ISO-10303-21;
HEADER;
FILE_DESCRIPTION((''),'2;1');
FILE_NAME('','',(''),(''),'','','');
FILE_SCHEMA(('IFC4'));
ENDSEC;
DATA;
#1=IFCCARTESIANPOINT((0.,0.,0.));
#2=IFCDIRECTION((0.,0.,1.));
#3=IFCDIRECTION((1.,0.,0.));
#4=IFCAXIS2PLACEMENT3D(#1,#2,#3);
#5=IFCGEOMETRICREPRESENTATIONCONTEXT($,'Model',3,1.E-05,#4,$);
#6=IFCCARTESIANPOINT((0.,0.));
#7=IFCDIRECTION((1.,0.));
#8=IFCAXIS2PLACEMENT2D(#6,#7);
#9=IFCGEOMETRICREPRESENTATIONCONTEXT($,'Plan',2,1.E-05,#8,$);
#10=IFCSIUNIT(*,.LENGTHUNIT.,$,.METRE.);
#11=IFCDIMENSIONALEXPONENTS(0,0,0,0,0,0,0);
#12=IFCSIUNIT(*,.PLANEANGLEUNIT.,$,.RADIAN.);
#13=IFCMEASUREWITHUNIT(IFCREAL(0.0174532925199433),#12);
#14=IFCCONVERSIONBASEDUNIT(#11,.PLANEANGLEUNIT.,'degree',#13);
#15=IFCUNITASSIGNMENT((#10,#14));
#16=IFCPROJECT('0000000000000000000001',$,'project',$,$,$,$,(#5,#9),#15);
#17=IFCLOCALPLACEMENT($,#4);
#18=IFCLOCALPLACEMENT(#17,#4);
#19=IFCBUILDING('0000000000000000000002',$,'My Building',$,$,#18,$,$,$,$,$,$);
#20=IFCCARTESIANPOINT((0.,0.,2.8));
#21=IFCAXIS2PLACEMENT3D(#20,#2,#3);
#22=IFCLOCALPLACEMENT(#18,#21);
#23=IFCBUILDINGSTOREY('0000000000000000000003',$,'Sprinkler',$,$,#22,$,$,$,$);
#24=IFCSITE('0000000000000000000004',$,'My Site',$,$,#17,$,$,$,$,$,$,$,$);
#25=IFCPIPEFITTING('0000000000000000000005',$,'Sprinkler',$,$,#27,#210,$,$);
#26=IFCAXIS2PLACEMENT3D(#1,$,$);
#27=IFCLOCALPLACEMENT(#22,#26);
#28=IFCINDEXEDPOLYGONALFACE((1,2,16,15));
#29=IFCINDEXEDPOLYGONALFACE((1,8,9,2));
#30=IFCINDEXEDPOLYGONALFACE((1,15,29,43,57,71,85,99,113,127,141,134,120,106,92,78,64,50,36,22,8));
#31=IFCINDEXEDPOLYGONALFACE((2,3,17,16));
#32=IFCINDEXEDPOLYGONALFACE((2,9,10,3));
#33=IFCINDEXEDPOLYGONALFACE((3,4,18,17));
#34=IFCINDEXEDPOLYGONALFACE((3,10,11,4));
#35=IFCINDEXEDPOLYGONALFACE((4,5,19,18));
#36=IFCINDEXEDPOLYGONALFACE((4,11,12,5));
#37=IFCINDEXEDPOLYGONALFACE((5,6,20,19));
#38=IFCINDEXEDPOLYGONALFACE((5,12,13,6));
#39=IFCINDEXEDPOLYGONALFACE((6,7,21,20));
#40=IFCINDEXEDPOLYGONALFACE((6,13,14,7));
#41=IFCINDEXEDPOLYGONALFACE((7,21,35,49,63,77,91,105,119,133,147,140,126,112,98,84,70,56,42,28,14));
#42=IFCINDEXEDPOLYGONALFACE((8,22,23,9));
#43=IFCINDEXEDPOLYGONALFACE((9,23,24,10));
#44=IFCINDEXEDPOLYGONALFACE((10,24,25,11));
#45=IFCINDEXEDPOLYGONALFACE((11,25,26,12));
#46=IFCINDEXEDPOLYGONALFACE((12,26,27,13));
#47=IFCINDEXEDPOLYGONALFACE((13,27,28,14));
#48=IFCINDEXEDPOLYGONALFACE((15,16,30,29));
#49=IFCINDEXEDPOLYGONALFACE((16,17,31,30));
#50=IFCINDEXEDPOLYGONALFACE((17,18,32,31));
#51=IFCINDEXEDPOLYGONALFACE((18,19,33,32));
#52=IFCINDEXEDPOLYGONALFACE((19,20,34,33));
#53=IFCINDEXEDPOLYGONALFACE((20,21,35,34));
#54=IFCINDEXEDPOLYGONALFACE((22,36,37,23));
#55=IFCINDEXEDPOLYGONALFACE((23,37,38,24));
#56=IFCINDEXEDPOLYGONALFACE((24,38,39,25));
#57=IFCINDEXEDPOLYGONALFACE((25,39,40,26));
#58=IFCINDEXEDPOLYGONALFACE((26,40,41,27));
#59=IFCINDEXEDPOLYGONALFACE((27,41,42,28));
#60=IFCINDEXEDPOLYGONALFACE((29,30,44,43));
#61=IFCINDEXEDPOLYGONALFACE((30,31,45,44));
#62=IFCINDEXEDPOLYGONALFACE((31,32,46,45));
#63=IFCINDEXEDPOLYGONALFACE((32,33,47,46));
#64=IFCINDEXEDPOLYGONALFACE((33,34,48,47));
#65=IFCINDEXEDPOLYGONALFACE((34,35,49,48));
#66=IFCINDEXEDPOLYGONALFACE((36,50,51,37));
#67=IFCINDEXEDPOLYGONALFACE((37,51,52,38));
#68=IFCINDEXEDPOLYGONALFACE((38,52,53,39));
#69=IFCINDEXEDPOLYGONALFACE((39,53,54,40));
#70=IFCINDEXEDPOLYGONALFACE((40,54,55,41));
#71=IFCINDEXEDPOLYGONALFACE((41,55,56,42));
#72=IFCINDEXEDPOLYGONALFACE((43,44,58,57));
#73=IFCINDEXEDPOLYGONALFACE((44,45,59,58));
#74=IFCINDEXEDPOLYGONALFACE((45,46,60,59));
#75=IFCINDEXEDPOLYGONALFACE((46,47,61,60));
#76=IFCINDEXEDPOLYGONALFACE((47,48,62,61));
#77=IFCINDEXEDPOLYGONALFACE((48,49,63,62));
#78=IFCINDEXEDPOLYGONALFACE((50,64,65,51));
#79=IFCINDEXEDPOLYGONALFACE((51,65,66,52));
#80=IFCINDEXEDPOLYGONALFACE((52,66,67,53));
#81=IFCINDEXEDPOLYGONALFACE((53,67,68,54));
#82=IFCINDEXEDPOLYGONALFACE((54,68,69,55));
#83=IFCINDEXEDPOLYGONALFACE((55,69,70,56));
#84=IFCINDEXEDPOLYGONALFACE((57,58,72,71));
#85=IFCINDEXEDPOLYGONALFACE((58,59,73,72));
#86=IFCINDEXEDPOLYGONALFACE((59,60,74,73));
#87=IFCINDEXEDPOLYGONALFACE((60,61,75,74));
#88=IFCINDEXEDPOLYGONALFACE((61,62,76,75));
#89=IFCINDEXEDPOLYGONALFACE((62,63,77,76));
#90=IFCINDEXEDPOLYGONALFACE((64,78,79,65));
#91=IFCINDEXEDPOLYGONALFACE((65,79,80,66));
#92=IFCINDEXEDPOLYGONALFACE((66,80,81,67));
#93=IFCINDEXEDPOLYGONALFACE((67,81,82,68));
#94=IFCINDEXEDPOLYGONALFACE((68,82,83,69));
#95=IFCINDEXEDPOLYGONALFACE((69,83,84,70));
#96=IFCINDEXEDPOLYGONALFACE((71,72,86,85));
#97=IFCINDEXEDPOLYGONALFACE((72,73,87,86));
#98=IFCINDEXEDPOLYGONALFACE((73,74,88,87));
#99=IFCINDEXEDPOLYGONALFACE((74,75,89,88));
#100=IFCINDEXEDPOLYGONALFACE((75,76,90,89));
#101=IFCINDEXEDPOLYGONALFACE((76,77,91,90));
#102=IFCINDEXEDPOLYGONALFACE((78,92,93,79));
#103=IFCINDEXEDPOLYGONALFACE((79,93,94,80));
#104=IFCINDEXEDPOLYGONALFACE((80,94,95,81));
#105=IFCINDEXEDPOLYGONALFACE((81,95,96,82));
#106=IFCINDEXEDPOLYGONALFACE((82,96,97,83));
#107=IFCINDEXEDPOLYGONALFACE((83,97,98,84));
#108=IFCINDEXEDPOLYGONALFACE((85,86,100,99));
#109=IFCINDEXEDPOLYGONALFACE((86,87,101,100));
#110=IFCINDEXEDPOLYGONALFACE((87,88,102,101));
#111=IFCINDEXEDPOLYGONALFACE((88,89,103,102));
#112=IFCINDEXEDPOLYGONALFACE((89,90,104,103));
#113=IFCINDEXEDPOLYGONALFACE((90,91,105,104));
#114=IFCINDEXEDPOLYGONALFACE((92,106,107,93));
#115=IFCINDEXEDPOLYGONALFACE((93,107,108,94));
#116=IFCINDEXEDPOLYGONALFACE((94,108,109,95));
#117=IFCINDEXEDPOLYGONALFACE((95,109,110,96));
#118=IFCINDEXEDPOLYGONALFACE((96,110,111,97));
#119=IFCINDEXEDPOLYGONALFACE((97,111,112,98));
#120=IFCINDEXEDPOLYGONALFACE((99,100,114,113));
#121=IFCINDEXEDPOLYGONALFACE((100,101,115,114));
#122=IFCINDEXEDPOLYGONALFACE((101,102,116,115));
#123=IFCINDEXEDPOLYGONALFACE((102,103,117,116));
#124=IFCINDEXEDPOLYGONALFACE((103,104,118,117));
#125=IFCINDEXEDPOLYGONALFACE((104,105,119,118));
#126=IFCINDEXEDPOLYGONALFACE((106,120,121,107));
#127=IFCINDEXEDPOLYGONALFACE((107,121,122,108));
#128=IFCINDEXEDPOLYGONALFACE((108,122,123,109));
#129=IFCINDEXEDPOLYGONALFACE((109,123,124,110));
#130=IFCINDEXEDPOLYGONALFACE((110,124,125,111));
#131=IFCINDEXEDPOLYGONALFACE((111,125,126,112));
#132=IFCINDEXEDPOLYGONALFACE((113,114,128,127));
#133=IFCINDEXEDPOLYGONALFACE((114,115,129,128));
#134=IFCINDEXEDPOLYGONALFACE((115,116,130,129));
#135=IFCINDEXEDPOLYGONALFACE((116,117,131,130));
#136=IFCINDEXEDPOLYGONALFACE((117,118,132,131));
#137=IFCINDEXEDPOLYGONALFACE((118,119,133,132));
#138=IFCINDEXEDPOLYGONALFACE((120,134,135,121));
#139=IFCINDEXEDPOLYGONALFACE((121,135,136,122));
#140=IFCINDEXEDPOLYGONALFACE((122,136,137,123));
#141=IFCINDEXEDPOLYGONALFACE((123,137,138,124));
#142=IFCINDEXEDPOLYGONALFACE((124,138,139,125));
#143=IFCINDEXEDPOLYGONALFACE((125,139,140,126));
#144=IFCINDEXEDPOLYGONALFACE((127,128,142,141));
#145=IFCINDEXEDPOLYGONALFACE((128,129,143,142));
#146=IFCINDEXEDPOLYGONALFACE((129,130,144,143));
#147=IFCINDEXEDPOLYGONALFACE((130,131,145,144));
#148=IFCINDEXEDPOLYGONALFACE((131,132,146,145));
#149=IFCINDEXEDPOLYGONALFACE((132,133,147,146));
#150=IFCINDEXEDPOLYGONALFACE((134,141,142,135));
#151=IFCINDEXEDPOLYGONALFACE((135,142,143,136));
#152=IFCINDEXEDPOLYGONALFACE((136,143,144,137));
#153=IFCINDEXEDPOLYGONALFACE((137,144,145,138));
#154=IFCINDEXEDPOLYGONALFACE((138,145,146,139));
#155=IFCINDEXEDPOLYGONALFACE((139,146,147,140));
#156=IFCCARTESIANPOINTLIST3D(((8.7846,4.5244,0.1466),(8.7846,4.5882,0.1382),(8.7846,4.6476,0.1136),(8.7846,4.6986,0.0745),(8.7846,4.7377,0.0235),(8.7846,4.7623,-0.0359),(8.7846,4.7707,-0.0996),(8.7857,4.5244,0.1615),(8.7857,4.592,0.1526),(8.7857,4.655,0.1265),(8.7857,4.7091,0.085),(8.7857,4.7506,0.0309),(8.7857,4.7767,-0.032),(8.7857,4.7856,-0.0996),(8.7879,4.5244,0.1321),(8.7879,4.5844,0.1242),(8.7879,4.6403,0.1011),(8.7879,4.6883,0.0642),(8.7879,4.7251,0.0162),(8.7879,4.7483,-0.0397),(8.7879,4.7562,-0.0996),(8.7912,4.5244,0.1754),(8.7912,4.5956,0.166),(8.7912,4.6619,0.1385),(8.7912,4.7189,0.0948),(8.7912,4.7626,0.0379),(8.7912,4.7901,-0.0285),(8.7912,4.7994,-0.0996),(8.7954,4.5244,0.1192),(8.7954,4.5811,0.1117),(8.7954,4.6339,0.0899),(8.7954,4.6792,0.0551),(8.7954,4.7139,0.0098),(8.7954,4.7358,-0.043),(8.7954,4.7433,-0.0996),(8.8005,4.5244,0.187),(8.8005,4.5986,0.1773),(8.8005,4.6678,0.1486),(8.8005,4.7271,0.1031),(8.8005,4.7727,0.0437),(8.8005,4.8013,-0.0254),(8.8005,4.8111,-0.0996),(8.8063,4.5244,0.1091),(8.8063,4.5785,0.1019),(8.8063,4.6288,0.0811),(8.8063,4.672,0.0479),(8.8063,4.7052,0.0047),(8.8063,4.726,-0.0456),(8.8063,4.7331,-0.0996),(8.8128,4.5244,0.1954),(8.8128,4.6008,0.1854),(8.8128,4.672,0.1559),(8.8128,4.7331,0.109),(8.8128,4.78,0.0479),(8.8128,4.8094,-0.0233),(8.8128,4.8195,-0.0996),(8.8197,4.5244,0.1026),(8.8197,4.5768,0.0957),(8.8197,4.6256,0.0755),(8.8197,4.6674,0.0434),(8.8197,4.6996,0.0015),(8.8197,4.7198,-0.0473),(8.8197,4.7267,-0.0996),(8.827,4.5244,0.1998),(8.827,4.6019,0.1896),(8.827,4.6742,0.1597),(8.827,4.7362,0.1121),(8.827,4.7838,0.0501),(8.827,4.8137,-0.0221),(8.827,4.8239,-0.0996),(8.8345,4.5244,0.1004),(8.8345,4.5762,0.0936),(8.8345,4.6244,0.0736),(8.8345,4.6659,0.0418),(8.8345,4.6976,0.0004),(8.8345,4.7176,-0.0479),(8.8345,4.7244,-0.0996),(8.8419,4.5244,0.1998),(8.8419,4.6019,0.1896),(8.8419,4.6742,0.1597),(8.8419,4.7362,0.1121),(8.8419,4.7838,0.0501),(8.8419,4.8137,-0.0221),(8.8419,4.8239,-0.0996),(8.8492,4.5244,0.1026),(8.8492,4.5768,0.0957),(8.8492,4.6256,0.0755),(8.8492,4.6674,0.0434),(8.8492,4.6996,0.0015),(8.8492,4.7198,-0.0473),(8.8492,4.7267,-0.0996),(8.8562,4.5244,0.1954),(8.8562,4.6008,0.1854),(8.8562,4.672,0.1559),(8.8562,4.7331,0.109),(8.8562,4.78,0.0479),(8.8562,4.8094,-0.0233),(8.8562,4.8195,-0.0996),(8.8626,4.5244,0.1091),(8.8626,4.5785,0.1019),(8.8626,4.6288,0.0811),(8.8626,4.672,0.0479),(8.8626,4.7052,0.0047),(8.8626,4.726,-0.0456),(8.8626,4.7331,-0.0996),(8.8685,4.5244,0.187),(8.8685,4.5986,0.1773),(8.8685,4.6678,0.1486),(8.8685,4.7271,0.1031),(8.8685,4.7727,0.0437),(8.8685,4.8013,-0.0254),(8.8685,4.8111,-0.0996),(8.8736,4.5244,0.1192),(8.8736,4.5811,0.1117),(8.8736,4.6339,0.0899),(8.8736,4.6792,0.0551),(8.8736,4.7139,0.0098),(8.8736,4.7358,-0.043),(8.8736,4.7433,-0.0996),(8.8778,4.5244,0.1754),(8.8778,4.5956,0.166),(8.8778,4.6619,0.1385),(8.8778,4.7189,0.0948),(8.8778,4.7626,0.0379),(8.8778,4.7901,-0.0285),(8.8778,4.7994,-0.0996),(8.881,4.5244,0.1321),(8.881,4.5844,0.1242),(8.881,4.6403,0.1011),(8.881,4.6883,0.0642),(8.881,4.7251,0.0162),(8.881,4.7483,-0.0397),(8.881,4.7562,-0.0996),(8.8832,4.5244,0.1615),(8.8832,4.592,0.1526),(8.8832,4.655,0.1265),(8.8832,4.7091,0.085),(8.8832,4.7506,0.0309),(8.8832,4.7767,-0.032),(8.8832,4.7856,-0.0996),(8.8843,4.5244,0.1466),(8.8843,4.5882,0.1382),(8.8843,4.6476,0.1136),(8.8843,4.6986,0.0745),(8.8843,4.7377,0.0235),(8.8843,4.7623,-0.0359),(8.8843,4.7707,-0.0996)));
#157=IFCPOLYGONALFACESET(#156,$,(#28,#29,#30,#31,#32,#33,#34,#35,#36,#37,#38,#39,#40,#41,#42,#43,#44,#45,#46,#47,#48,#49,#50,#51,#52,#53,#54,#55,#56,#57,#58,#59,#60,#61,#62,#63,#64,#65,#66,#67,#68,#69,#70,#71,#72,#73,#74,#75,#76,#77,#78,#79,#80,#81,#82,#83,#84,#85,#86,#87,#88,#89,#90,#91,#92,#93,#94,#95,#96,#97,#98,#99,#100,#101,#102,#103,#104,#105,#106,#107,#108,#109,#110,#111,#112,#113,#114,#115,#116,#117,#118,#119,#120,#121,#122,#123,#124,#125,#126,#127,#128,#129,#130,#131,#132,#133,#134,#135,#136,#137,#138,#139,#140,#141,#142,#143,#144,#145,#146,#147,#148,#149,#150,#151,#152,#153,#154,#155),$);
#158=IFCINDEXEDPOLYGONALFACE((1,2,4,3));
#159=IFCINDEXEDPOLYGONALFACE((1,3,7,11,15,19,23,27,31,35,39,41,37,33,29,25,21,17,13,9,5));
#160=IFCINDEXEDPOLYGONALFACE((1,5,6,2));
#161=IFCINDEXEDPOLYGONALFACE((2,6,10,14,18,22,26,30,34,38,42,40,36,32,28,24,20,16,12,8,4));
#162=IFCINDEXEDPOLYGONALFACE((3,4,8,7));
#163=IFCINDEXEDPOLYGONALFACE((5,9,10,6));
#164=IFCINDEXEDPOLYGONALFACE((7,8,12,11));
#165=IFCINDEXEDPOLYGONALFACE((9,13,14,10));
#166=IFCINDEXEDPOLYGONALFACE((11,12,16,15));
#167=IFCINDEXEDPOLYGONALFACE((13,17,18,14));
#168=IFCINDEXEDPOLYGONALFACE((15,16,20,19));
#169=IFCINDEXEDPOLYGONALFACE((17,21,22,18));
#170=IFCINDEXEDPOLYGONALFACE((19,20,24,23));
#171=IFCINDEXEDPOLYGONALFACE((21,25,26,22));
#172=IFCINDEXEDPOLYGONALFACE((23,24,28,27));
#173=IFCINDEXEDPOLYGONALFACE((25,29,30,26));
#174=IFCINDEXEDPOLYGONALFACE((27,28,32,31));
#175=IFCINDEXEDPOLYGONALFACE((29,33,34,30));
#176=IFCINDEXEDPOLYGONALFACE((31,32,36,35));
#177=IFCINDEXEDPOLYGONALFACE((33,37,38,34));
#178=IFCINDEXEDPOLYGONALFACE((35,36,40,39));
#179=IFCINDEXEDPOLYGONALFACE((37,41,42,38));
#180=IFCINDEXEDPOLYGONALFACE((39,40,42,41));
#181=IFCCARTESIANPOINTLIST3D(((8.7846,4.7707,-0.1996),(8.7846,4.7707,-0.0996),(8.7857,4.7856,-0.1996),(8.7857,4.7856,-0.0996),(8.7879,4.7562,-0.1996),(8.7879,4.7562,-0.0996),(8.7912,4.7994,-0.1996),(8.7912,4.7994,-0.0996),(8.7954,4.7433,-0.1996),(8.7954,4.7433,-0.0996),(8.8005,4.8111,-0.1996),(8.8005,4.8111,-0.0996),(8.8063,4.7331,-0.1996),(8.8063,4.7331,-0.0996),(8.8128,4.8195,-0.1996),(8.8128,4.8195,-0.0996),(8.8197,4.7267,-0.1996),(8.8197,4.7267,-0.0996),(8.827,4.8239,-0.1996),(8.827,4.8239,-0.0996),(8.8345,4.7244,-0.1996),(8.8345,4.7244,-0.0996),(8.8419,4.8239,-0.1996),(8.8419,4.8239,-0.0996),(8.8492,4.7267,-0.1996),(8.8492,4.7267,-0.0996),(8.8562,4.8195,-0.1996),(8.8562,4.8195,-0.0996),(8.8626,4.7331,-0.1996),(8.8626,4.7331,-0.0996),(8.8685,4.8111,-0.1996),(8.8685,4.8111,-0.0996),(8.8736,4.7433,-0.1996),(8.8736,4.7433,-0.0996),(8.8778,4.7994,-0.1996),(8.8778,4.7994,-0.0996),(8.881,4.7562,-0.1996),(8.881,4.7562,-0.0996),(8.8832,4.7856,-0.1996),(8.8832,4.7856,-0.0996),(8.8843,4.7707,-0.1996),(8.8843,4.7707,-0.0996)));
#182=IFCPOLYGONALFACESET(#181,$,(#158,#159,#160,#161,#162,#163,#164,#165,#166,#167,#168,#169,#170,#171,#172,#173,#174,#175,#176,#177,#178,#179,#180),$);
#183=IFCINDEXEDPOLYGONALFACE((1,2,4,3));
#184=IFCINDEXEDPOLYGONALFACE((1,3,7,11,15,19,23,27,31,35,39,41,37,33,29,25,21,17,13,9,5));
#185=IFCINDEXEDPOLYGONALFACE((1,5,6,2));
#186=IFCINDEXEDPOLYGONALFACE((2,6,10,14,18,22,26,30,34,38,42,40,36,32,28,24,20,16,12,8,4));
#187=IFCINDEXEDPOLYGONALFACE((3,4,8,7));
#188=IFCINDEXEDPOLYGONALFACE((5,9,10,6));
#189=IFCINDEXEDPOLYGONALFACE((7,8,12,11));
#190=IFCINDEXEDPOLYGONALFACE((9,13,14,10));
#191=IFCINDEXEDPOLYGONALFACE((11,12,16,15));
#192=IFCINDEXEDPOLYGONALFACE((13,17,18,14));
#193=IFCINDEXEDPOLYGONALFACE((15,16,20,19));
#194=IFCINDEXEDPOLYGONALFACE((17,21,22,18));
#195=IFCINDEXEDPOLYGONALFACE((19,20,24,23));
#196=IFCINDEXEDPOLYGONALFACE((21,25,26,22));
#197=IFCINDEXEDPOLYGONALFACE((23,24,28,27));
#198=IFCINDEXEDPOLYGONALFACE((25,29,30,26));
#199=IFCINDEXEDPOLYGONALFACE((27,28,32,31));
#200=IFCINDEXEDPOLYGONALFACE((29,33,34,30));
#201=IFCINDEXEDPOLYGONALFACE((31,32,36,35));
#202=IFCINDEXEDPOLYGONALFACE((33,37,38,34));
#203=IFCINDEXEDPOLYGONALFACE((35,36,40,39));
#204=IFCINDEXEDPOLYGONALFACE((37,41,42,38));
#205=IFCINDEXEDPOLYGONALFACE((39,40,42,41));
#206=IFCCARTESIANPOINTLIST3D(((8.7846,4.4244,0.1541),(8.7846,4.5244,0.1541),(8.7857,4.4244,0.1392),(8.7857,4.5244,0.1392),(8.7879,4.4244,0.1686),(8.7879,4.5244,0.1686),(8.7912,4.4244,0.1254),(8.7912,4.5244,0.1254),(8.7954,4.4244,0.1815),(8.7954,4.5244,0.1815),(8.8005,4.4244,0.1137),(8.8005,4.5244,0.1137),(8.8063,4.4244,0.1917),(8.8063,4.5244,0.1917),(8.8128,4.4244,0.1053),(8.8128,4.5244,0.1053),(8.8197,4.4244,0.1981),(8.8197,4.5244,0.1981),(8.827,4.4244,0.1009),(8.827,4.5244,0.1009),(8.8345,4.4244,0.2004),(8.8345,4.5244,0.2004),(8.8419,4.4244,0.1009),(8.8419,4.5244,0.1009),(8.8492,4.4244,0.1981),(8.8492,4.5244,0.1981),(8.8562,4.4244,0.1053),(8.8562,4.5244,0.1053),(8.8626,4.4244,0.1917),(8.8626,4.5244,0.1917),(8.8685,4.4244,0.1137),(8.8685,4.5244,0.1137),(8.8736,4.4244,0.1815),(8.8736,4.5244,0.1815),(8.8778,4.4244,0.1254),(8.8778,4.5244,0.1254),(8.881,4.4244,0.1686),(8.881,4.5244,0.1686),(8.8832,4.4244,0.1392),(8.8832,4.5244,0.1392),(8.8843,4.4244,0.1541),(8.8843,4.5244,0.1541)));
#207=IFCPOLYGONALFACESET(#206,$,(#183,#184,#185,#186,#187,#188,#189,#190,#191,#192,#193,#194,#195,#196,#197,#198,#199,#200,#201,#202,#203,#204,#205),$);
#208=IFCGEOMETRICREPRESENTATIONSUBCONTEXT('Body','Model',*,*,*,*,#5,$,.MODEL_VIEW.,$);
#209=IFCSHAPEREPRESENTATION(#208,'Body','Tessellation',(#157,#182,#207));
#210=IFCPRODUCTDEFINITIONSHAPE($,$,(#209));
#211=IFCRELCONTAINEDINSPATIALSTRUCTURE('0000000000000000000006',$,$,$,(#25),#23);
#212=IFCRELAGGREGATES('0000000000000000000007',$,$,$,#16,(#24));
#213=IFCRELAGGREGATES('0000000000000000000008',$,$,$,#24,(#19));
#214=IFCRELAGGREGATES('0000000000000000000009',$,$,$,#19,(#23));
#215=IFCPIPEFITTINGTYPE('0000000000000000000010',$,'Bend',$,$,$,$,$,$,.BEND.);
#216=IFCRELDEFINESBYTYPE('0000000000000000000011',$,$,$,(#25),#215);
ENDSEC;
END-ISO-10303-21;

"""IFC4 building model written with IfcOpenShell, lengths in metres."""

from ifc_helpers import new_model, entity, si_unit, converted_unit, frame, origin_with_axes, origin_2d_with_axis, place, context, subcontext, project, spatial, circle, extrude, source, transform, mapped, type_object, type_shapes, element, save


model = new_model("IFC4")

# Units and contexts
model_context = context("Model", 3, precision=1e-05, world=origin_with_axes())
plan_context = context("Plan", 2, precision=1e-05, world=origin_2d_with_axis())
body_context = subcontext(model_context, "Body", "Model", "MODEL_VIEW")
ifc_project = project(units=[si_unit("LENGTHUNIT", "METRE"), converted_unit("PLANEANGLEUNIT", "degree", entity("IfcReal", 0.0174532925199433), si_unit("PLANEANGLEUNIT", "RADIAN"), dimensions=[0, 0, 0, 0, 0, 0, 0])], contexts=[model_context, plan_context])

# Site, building, storey
site_placement = place(None, origin_with_axes())
site = spatial("IfcSite", under=ifc_project, at=site_placement, Name="My Site")
building_placement = place(site_placement, origin_with_axes())
building = spatial("IfcBuilding", under=site, at=building_placement, Name="My Building")
storey_placement = place(building_placement, frame((0.0, 0.0, 2.8), z_axis=(0.0, 0.0, 1.0), x_axis=(1.0, 0.0, 0.0)))
storey = spatial("IfcBuildingStorey", under=building, at=storey_placement, Name="Sprinkler")

# Pipe fitting
pipe_fitting_type_1 = type_object("IfcPipeFittingType", Name="Bend", PredefinedType="BEND")
shared_shape = source(origin_with_axes(), body_context, "Body", "SolidModel", [
    entity("IfcSweptDiskSolid", entity("IfcIndexedPolyCurve", entity("IfcCartesianPointList3D", [[0.0, 0.0, 0.1], [0.0732, 0.0, 0.2768], [0.25, 0.0, 0.35]]), [entity("IfcArcIndex", [1, 2, 3])]), 0.05),
    extrude(circle(Radius=0.05), origin_with_axes(), (0.0, 0.0, 1.0), 0.1),
    extrude(circle(Radius=0.05), frame((0.25, 0.0, 0.35), z_axis=(1.0, 0.0, 0.000001), x_axis=(-0.000001, 0.0, 1.0)), (0.0, 0.0, 1.0), 0.1),
])
type_shapes(pipe_fitting_type_1, [shared_shape])
for number, where, z_axis, x_axis, name in (
    (1, (8.8345, 4.7744, -0.1996), (0.0, -0.000008, 1.0), (0.0, -1.0, -0.000008), "Sprinkler"),
):
    element("IfcPipeFitting", number, at=place(storey_placement, frame(where, z_axis=z_axis, x_axis=x_axis)), inside=storey, type_object=pipe_fitting_type_1, Name=name, context=body_context, shape_type="MappedRepresentation", body=[
        mapped(shared_shape, transform((0.0, 0.0, 0.0), x_axis=(1.0, 0.0, 0.0), y_axis=(0.0, 1.0, 0.0), z_axis=(0.0, 0.0, 1.0), scale=1.0)),
    ])

save(model, "model.ifc")
